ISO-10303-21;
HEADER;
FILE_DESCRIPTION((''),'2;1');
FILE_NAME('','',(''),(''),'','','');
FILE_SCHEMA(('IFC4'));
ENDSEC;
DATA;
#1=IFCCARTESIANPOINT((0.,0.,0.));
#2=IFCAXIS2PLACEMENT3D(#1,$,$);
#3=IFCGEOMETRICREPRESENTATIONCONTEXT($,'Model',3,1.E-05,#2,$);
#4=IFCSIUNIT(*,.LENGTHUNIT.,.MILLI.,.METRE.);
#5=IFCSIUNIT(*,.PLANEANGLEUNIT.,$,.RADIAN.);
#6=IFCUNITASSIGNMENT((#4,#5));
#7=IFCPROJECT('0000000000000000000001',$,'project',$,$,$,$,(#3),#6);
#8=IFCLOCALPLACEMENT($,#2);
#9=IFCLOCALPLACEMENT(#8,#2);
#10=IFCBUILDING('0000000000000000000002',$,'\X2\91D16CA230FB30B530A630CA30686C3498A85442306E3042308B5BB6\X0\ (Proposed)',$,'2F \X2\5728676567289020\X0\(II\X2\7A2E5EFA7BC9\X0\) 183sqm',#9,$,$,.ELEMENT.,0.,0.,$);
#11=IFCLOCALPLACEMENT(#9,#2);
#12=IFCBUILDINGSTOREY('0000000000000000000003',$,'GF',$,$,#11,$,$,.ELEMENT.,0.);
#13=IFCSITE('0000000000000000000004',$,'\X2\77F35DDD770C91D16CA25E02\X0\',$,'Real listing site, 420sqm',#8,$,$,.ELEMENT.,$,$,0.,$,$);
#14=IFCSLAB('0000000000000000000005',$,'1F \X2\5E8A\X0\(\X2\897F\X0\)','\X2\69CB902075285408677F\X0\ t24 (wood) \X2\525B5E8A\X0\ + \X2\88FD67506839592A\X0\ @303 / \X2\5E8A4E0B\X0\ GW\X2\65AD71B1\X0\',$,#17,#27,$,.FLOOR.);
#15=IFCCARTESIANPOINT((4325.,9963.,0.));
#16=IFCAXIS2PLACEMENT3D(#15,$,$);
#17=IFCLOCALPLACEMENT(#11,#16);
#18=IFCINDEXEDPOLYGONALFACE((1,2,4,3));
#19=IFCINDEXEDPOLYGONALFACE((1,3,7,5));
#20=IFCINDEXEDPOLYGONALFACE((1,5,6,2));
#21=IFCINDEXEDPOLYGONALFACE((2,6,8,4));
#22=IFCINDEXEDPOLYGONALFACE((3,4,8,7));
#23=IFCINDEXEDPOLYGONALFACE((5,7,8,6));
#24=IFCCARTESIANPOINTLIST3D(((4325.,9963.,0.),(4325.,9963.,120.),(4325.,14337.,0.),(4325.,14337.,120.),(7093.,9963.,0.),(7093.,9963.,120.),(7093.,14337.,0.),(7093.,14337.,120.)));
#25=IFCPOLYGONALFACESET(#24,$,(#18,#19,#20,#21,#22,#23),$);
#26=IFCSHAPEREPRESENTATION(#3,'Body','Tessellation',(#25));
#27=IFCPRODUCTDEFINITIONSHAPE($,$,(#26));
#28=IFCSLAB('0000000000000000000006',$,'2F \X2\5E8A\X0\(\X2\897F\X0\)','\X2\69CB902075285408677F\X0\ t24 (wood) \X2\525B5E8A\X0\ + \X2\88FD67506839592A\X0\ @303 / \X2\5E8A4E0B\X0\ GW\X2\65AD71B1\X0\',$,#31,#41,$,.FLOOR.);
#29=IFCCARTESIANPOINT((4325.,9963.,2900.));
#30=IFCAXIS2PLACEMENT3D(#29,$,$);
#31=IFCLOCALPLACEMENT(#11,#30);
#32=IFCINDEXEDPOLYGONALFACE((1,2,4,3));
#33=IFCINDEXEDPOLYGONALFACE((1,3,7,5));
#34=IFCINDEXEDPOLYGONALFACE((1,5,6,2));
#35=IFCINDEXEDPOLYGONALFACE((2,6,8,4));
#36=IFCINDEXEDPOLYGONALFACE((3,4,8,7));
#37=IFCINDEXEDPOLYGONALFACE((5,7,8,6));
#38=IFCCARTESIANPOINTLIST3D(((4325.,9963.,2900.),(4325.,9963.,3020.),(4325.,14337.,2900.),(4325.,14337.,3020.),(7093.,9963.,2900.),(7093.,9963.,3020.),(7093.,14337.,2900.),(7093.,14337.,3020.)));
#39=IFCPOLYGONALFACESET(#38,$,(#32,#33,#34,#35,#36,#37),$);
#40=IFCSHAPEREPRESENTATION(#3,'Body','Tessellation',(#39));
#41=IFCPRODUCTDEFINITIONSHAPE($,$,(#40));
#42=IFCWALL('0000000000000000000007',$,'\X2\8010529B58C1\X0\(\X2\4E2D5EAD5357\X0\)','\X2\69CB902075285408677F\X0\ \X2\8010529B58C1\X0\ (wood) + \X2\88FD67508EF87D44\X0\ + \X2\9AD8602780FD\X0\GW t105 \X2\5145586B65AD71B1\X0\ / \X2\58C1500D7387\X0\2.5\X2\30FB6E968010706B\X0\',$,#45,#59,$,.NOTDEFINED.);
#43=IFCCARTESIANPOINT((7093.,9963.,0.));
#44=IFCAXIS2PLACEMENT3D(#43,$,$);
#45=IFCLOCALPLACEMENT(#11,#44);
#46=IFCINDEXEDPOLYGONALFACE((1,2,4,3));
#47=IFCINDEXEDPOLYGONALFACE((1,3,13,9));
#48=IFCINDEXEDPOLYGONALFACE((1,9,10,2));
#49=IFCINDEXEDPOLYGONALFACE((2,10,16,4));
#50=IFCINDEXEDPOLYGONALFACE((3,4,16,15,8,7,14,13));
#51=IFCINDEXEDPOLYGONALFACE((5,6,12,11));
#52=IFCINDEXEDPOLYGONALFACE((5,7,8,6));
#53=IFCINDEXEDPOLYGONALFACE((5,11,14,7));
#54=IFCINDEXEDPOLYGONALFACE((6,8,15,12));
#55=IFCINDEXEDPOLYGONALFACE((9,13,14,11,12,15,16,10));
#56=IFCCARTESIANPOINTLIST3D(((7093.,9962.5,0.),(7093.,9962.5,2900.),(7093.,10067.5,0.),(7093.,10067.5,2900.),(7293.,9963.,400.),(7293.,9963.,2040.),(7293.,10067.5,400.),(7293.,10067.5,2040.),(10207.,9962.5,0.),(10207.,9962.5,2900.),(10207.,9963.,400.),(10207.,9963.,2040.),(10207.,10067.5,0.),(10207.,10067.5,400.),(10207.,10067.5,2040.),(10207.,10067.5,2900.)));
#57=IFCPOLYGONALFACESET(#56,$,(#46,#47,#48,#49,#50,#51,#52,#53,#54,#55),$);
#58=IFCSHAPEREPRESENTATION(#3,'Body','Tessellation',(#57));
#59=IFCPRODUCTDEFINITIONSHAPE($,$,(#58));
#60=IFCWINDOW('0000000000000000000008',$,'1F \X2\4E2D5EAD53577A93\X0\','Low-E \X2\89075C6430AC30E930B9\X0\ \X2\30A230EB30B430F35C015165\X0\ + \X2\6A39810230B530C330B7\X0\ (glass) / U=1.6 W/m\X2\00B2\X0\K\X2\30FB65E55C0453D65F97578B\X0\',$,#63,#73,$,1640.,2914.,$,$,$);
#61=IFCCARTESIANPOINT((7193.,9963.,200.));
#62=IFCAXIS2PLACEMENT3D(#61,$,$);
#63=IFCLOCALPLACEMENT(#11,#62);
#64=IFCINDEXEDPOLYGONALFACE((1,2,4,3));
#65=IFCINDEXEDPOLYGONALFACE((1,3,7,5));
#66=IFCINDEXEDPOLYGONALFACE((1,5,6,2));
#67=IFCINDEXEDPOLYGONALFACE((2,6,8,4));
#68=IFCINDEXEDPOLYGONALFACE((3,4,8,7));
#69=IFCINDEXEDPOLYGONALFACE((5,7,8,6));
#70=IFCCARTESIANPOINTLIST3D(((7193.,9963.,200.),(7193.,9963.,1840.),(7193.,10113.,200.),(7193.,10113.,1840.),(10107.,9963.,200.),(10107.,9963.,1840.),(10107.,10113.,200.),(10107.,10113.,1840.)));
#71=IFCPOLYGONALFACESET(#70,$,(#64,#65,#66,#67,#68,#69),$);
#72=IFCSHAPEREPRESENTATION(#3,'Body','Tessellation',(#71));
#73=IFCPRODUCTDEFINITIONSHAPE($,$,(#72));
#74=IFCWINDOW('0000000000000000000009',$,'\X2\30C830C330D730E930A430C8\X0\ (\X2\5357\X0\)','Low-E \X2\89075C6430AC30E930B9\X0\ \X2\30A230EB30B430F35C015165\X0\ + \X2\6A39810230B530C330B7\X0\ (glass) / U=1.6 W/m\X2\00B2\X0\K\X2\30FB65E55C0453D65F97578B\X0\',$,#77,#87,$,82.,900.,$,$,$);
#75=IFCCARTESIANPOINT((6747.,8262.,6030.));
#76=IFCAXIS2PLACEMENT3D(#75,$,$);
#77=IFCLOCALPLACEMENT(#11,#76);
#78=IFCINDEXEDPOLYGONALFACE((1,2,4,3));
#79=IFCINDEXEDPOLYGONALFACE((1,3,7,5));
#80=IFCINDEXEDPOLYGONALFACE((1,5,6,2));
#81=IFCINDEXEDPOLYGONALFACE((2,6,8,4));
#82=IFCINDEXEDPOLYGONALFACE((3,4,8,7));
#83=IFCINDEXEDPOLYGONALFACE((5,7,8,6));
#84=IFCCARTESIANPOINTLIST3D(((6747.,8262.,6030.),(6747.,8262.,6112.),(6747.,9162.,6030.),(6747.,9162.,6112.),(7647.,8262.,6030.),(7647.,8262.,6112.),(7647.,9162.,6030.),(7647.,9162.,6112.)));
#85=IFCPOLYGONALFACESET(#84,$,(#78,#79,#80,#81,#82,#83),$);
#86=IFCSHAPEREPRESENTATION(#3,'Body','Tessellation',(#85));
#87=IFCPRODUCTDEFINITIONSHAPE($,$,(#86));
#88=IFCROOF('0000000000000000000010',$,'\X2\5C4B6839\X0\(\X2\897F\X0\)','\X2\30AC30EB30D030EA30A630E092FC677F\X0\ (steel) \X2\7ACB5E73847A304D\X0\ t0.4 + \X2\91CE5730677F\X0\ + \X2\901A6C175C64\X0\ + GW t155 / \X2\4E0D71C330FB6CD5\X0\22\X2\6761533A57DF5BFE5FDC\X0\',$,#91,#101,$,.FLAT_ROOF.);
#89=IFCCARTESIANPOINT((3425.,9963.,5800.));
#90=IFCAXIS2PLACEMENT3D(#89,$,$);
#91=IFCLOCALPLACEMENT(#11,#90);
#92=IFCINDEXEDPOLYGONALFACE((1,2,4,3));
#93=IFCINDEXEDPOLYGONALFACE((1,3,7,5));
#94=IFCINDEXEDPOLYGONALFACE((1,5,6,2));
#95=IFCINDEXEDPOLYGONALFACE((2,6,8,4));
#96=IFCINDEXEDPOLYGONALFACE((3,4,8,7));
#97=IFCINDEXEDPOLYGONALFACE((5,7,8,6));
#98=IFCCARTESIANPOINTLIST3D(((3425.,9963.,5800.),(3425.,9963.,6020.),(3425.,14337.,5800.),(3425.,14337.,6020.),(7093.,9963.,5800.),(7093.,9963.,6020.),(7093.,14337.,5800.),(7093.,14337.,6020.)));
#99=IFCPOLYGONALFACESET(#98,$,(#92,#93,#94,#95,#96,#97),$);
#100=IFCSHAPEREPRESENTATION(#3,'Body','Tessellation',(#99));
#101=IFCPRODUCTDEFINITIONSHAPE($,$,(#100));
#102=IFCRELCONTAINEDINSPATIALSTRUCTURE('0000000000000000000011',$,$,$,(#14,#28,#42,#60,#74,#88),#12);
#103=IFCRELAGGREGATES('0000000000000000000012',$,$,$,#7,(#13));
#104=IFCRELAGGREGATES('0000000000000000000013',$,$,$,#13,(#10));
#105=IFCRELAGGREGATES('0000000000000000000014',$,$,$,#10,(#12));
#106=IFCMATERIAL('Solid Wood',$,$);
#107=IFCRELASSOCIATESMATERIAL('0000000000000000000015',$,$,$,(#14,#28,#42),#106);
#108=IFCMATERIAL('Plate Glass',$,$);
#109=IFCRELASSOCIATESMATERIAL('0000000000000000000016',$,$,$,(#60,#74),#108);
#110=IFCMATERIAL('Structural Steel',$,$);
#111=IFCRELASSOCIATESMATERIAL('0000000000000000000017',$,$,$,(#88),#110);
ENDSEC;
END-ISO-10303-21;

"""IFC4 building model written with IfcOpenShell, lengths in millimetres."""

from ifc_helpers import new_model, si_unit, frame, frame_2d, origin, place, context, project, spatial, rectangle, extrude, material, element, fill, save


model = new_model("IFC4")

# Units and contexts
model_context = context("Model", 3, precision=1e-05, world=origin())
ifc_project = project(units=[si_unit("LENGTHUNIT", "METRE", prefix="MILLI"), si_unit("PLANEANGLEUNIT", "RADIAN")], contexts=[model_context])

# Site, building, storey
site_placement = place(None, origin())
site = spatial("IfcSite", under=ifc_project, at=site_placement, Name="石川県金沢市", ObjectType="Real listing site, 420sqm", CompositionType="ELEMENT", RefElevation=0.0)
building_placement = place(site_placement, origin())
building = spatial("IfcBuilding", under=site, at=building_placement, Name="金沢・サウナと水風呂のある家 (Proposed)", ObjectType="2F 在来木造(II種建築) 183sqm", CompositionType="ELEMENT", ElevationOfRefHeight=0.0, ElevationOfTerrain=0.0)
storey_placement = place(building_placement, origin())
storey = spatial("IfcBuildingStorey", under=building, at=storey_placement, Name="GF", CompositionType="ELEMENT", Elevation=0.0)

# Shared definitions
ifc_material_1 = material(Name="Solid Wood")

# Slabs
slab_1_placement = place(storey_placement, frame((4325.0, 9963.0, 0.0)))
element("IfcSlab", 1, at=slab_1_placement, inside=storey, material=ifc_material_1, Name="1F 床(西)", Description="構造用合板 t24 (wood) 剛床 + 製材根太 @303 / 床下 GW断熱", PredefinedType="FLOOR", context=model_context, shape_type="SweptSolid", body=[
    extrude(rectangle(XDim=2768.0, YDim=4374.0, at=frame_2d((1384.0, 2187.0))), frame((4325.0, 9963.0, 0.0)), (0.0, 0.0, 1.0), 120.0),
])
slab_2_placement = place(storey_placement, frame((4325.0, 9963.0, 2900.0)))
element("IfcSlab", 2, at=slab_2_placement, inside=storey, material=ifc_material_1, Name="2F 床(西)", Description="構造用合板 t24 (wood) 剛床 + 製材根太 @303 / 床下 GW断熱", PredefinedType="FLOOR", context=model_context, shape_type="SweptSolid", body=[
    extrude(rectangle(XDim=2768.0, YDim=4374.0, at=frame_2d((1384.0, 2187.0))), frame((4325.0, 9963.0, 2900.0)), (0.0, 0.0, 1.0), 120.0),
])

# Wall, opening, window
wall_1_placement = place(storey_placement, frame((7093.0, 9963.0, 0.0)))
wall_1 = element("IfcWall", 3, at=wall_1_placement, inside=storey, material=ifc_material_1, Name="耐力壁(中庭南)", Description="構造用合板 耐力壁 (wood) + 製材軸組 + 高性能GW t105 充填断熱 / 壁倍率2.5・準耐火", PredefinedType="NOTDEFINED", context=model_context, shape_type="SweptSolid", body=[
    extrude(rectangle(XDim=3114.0, YDim=105.0, at=frame_2d((1557.0, 52.0))), frame((7093.0, 9963.0, 0.0)), (0.0, 0.0, 1.0), 2900.0),
])
opening_placement = place(storey_placement, frame((7193.0, 9963.0, 200.0)))
opening = element("IfcOpeningElement", 4, at=opening_placement, cuts=wall_1, PredefinedType="NOTDEFINED", context=model_context, shape_type="SweptSolid", body=[
    extrude(rectangle(XDim=2914.0, YDim=150.0, at=frame_2d((1457.0, 75.0))), frame((7193.0, 9963.0, 200.0)), (0.0, 0.0, 1.0), 1640.0),
])
ifc_material_2 = material(Name="Plate Glass")
window_1_placement = place(storey_placement, frame((7193.0, 9963.0, 200.0)))
window_1 = element("IfcWindow", 5, at=window_1_placement, inside=storey, material=ifc_material_2, Name="1F 中庭南窓", Description="Low-E 複層ガラス アルゴン封入 + 樹脂サッシ (glass) / U=1.6 W/m²K・日射取得型", OverallHeight=1640.0, OverallWidth=2914.0, context=model_context, shape_type="SweptSolid", body=[
    extrude(rectangle(XDim=2914.0, YDim=150.0, at=frame_2d((1457.0, 75.0))), frame((7193.0, 9963.0, 200.0)), (0.0, 0.0, 1.0), 1640.0),
])
fill(opening, window_1)

# Window
window_2_placement = place(storey_placement, frame((6747.0, 8262.0, 6030.0)))
element("IfcWindow", 6, at=window_2_placement, inside=storey, material=ifc_material_2, Name="トップライト (南)", Description="Low-E 複層ガラス アルゴン封入 + 樹脂サッシ (glass) / U=1.6 W/m²K・日射取得型", OverallHeight=82.0, OverallWidth=900.0, context=model_context, shape_type="SweptSolid", body=[
    extrude(rectangle(XDim=900.0, YDim=900.0, at=frame_2d((450.0, 450.0))), frame((6747.0, 8262.0, 6030.0)), (0.0, 0.0, 1.0), 82.0),
])

# Roof
ifc_material_3 = material(Name="Structural Steel")
for number, where, name in (
    (7, (3425.0, 9963.0, 5800.0), "屋根(西)"),
):
    element("IfcRoof", number, at=place(storey_placement, frame(where)), inside=storey, material=ifc_material_3, Name=name, Description="ガルバリウム鋼板 (steel) 立平葺き t0.4 + 野地板 + 通気層 + GW t155 / 不燃・法22条区域対応", PredefinedType="FLAT_ROOF", context=model_context, shape_type="SweptSolid", body=[
        extrude(rectangle(XDim=3668.0, YDim=4374.0, at=frame_2d((1834.0, 2187.0))), frame((3425.0, 9963.0, 5800.0)), (0.0, 0.0, 1.0), 220.0),
    ])

save(model, "model.ifc")
